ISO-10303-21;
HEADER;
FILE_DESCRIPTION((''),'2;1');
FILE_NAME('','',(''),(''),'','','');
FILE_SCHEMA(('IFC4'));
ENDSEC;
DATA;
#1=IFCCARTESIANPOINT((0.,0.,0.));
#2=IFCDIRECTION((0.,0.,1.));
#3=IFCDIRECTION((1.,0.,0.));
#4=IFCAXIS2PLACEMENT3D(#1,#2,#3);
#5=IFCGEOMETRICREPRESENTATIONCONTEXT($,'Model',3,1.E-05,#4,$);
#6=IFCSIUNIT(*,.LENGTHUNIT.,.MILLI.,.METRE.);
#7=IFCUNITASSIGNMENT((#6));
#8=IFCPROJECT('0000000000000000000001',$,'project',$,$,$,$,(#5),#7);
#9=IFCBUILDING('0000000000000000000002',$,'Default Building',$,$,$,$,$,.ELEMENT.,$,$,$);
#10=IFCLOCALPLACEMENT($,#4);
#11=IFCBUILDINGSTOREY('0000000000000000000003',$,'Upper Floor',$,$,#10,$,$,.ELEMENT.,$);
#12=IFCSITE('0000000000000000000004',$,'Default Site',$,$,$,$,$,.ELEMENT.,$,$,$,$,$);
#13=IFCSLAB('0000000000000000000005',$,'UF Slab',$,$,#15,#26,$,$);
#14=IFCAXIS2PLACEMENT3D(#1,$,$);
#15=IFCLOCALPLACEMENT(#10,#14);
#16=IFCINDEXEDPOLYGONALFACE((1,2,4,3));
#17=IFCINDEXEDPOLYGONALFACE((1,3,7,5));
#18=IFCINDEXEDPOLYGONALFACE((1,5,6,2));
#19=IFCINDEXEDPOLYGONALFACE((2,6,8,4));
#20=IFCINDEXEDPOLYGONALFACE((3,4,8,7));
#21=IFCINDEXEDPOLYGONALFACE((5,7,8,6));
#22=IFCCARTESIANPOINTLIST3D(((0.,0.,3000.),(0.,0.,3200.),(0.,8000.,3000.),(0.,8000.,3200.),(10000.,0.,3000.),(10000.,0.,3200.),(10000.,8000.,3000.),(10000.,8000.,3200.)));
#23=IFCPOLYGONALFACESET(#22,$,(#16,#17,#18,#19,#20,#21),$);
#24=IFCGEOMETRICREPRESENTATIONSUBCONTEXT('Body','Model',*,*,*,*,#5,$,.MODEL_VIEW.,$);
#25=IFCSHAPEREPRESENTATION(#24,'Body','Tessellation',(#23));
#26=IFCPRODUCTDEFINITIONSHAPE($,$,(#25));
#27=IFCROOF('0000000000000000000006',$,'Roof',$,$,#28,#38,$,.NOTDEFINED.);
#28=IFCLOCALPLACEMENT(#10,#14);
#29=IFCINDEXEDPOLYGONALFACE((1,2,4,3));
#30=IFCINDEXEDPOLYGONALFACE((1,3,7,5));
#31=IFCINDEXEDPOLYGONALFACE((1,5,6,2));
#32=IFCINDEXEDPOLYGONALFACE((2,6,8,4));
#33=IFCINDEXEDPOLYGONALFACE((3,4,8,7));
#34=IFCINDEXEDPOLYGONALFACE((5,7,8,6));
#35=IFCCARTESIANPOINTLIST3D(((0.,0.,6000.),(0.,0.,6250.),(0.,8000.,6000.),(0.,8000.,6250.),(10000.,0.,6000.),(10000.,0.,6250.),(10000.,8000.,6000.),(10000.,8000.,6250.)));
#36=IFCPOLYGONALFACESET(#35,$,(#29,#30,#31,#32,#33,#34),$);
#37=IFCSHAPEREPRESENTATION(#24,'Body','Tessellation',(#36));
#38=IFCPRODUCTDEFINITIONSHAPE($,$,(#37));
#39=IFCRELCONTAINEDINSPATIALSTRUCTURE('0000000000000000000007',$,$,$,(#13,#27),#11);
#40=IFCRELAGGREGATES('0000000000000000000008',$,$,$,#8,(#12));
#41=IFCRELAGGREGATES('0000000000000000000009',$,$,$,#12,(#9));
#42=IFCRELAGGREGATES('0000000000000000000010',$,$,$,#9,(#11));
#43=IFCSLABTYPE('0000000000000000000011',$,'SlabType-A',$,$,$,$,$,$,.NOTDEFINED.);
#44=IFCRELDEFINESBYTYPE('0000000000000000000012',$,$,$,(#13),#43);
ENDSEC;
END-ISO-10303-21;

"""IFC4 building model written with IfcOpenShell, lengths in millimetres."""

from ifc_helpers import new_model, si_unit, frame, origin_with_axes, place, context, subcontext, project, spatial, polyline, outline, extrude, type_object, element, save


model = new_model("IFC4")

# Units and contexts
model_context = context("Model", 3, precision=1e-05, world=origin_with_axes())
body_context = subcontext(model_context, "Body", "Model", "MODEL_VIEW")
ifc_project = project(units=[si_unit("LENGTHUNIT", "METRE", prefix="MILLI")], contexts=[model_context])

# Site, building, storey
site = spatial("IfcSite", under=ifc_project, Name="Default Site", CompositionType="ELEMENT")
building = spatial("IfcBuilding", under=site, Name="Default Building", CompositionType="ELEMENT")
storey_placement = place(None, origin_with_axes())
storey = spatial("IfcBuildingStorey", under=building, at=storey_placement, Name="Upper Floor", CompositionType="ELEMENT")

# Slab
slab_type = type_object("IfcSlabType", Name="SlabType-A", PredefinedType="NOTDEFINED")
slab_placement = place(storey_placement, frame((0.0, 0.0, 3000.0), z_axis=(0.0, 0.0, 1.0), x_axis=(1.0, 0.0, 0.0)))
element("IfcSlab", 1, at=slab_placement, inside=storey, type_object=slab_type, Name="UF Slab", context=body_context, shape_type="SweptSolid", body=[
    extrude(outline(polyline([(0.0, 0.0), (10000.0, 0.0), (10000.0, 8000.0), (0.0, 8000.0), (0.0, 0.0)])), origin_with_axes(), (0.0, 0.0, 1.0), 200.0),
])

# Roof
roof_placement = place(storey_placement, frame((0.0, 0.0, 6000.0), z_axis=(0.0, 0.0, 1.0), x_axis=(1.0, 0.0, 0.0)))
element("IfcRoof", 2, at=roof_placement, inside=storey, Name="Roof", PredefinedType="NOTDEFINED", context=body_context, shape_type="SweptSolid", body=[
    extrude(outline(polyline([(0.0, 0.0), (10000.0, 0.0), (10000.0, 8000.0), (0.0, 8000.0), (0.0, 0.0)])), origin_with_axes(), (0.0, 0.0, 1.0), 250.0),
])

save(model, "model.ifc")
